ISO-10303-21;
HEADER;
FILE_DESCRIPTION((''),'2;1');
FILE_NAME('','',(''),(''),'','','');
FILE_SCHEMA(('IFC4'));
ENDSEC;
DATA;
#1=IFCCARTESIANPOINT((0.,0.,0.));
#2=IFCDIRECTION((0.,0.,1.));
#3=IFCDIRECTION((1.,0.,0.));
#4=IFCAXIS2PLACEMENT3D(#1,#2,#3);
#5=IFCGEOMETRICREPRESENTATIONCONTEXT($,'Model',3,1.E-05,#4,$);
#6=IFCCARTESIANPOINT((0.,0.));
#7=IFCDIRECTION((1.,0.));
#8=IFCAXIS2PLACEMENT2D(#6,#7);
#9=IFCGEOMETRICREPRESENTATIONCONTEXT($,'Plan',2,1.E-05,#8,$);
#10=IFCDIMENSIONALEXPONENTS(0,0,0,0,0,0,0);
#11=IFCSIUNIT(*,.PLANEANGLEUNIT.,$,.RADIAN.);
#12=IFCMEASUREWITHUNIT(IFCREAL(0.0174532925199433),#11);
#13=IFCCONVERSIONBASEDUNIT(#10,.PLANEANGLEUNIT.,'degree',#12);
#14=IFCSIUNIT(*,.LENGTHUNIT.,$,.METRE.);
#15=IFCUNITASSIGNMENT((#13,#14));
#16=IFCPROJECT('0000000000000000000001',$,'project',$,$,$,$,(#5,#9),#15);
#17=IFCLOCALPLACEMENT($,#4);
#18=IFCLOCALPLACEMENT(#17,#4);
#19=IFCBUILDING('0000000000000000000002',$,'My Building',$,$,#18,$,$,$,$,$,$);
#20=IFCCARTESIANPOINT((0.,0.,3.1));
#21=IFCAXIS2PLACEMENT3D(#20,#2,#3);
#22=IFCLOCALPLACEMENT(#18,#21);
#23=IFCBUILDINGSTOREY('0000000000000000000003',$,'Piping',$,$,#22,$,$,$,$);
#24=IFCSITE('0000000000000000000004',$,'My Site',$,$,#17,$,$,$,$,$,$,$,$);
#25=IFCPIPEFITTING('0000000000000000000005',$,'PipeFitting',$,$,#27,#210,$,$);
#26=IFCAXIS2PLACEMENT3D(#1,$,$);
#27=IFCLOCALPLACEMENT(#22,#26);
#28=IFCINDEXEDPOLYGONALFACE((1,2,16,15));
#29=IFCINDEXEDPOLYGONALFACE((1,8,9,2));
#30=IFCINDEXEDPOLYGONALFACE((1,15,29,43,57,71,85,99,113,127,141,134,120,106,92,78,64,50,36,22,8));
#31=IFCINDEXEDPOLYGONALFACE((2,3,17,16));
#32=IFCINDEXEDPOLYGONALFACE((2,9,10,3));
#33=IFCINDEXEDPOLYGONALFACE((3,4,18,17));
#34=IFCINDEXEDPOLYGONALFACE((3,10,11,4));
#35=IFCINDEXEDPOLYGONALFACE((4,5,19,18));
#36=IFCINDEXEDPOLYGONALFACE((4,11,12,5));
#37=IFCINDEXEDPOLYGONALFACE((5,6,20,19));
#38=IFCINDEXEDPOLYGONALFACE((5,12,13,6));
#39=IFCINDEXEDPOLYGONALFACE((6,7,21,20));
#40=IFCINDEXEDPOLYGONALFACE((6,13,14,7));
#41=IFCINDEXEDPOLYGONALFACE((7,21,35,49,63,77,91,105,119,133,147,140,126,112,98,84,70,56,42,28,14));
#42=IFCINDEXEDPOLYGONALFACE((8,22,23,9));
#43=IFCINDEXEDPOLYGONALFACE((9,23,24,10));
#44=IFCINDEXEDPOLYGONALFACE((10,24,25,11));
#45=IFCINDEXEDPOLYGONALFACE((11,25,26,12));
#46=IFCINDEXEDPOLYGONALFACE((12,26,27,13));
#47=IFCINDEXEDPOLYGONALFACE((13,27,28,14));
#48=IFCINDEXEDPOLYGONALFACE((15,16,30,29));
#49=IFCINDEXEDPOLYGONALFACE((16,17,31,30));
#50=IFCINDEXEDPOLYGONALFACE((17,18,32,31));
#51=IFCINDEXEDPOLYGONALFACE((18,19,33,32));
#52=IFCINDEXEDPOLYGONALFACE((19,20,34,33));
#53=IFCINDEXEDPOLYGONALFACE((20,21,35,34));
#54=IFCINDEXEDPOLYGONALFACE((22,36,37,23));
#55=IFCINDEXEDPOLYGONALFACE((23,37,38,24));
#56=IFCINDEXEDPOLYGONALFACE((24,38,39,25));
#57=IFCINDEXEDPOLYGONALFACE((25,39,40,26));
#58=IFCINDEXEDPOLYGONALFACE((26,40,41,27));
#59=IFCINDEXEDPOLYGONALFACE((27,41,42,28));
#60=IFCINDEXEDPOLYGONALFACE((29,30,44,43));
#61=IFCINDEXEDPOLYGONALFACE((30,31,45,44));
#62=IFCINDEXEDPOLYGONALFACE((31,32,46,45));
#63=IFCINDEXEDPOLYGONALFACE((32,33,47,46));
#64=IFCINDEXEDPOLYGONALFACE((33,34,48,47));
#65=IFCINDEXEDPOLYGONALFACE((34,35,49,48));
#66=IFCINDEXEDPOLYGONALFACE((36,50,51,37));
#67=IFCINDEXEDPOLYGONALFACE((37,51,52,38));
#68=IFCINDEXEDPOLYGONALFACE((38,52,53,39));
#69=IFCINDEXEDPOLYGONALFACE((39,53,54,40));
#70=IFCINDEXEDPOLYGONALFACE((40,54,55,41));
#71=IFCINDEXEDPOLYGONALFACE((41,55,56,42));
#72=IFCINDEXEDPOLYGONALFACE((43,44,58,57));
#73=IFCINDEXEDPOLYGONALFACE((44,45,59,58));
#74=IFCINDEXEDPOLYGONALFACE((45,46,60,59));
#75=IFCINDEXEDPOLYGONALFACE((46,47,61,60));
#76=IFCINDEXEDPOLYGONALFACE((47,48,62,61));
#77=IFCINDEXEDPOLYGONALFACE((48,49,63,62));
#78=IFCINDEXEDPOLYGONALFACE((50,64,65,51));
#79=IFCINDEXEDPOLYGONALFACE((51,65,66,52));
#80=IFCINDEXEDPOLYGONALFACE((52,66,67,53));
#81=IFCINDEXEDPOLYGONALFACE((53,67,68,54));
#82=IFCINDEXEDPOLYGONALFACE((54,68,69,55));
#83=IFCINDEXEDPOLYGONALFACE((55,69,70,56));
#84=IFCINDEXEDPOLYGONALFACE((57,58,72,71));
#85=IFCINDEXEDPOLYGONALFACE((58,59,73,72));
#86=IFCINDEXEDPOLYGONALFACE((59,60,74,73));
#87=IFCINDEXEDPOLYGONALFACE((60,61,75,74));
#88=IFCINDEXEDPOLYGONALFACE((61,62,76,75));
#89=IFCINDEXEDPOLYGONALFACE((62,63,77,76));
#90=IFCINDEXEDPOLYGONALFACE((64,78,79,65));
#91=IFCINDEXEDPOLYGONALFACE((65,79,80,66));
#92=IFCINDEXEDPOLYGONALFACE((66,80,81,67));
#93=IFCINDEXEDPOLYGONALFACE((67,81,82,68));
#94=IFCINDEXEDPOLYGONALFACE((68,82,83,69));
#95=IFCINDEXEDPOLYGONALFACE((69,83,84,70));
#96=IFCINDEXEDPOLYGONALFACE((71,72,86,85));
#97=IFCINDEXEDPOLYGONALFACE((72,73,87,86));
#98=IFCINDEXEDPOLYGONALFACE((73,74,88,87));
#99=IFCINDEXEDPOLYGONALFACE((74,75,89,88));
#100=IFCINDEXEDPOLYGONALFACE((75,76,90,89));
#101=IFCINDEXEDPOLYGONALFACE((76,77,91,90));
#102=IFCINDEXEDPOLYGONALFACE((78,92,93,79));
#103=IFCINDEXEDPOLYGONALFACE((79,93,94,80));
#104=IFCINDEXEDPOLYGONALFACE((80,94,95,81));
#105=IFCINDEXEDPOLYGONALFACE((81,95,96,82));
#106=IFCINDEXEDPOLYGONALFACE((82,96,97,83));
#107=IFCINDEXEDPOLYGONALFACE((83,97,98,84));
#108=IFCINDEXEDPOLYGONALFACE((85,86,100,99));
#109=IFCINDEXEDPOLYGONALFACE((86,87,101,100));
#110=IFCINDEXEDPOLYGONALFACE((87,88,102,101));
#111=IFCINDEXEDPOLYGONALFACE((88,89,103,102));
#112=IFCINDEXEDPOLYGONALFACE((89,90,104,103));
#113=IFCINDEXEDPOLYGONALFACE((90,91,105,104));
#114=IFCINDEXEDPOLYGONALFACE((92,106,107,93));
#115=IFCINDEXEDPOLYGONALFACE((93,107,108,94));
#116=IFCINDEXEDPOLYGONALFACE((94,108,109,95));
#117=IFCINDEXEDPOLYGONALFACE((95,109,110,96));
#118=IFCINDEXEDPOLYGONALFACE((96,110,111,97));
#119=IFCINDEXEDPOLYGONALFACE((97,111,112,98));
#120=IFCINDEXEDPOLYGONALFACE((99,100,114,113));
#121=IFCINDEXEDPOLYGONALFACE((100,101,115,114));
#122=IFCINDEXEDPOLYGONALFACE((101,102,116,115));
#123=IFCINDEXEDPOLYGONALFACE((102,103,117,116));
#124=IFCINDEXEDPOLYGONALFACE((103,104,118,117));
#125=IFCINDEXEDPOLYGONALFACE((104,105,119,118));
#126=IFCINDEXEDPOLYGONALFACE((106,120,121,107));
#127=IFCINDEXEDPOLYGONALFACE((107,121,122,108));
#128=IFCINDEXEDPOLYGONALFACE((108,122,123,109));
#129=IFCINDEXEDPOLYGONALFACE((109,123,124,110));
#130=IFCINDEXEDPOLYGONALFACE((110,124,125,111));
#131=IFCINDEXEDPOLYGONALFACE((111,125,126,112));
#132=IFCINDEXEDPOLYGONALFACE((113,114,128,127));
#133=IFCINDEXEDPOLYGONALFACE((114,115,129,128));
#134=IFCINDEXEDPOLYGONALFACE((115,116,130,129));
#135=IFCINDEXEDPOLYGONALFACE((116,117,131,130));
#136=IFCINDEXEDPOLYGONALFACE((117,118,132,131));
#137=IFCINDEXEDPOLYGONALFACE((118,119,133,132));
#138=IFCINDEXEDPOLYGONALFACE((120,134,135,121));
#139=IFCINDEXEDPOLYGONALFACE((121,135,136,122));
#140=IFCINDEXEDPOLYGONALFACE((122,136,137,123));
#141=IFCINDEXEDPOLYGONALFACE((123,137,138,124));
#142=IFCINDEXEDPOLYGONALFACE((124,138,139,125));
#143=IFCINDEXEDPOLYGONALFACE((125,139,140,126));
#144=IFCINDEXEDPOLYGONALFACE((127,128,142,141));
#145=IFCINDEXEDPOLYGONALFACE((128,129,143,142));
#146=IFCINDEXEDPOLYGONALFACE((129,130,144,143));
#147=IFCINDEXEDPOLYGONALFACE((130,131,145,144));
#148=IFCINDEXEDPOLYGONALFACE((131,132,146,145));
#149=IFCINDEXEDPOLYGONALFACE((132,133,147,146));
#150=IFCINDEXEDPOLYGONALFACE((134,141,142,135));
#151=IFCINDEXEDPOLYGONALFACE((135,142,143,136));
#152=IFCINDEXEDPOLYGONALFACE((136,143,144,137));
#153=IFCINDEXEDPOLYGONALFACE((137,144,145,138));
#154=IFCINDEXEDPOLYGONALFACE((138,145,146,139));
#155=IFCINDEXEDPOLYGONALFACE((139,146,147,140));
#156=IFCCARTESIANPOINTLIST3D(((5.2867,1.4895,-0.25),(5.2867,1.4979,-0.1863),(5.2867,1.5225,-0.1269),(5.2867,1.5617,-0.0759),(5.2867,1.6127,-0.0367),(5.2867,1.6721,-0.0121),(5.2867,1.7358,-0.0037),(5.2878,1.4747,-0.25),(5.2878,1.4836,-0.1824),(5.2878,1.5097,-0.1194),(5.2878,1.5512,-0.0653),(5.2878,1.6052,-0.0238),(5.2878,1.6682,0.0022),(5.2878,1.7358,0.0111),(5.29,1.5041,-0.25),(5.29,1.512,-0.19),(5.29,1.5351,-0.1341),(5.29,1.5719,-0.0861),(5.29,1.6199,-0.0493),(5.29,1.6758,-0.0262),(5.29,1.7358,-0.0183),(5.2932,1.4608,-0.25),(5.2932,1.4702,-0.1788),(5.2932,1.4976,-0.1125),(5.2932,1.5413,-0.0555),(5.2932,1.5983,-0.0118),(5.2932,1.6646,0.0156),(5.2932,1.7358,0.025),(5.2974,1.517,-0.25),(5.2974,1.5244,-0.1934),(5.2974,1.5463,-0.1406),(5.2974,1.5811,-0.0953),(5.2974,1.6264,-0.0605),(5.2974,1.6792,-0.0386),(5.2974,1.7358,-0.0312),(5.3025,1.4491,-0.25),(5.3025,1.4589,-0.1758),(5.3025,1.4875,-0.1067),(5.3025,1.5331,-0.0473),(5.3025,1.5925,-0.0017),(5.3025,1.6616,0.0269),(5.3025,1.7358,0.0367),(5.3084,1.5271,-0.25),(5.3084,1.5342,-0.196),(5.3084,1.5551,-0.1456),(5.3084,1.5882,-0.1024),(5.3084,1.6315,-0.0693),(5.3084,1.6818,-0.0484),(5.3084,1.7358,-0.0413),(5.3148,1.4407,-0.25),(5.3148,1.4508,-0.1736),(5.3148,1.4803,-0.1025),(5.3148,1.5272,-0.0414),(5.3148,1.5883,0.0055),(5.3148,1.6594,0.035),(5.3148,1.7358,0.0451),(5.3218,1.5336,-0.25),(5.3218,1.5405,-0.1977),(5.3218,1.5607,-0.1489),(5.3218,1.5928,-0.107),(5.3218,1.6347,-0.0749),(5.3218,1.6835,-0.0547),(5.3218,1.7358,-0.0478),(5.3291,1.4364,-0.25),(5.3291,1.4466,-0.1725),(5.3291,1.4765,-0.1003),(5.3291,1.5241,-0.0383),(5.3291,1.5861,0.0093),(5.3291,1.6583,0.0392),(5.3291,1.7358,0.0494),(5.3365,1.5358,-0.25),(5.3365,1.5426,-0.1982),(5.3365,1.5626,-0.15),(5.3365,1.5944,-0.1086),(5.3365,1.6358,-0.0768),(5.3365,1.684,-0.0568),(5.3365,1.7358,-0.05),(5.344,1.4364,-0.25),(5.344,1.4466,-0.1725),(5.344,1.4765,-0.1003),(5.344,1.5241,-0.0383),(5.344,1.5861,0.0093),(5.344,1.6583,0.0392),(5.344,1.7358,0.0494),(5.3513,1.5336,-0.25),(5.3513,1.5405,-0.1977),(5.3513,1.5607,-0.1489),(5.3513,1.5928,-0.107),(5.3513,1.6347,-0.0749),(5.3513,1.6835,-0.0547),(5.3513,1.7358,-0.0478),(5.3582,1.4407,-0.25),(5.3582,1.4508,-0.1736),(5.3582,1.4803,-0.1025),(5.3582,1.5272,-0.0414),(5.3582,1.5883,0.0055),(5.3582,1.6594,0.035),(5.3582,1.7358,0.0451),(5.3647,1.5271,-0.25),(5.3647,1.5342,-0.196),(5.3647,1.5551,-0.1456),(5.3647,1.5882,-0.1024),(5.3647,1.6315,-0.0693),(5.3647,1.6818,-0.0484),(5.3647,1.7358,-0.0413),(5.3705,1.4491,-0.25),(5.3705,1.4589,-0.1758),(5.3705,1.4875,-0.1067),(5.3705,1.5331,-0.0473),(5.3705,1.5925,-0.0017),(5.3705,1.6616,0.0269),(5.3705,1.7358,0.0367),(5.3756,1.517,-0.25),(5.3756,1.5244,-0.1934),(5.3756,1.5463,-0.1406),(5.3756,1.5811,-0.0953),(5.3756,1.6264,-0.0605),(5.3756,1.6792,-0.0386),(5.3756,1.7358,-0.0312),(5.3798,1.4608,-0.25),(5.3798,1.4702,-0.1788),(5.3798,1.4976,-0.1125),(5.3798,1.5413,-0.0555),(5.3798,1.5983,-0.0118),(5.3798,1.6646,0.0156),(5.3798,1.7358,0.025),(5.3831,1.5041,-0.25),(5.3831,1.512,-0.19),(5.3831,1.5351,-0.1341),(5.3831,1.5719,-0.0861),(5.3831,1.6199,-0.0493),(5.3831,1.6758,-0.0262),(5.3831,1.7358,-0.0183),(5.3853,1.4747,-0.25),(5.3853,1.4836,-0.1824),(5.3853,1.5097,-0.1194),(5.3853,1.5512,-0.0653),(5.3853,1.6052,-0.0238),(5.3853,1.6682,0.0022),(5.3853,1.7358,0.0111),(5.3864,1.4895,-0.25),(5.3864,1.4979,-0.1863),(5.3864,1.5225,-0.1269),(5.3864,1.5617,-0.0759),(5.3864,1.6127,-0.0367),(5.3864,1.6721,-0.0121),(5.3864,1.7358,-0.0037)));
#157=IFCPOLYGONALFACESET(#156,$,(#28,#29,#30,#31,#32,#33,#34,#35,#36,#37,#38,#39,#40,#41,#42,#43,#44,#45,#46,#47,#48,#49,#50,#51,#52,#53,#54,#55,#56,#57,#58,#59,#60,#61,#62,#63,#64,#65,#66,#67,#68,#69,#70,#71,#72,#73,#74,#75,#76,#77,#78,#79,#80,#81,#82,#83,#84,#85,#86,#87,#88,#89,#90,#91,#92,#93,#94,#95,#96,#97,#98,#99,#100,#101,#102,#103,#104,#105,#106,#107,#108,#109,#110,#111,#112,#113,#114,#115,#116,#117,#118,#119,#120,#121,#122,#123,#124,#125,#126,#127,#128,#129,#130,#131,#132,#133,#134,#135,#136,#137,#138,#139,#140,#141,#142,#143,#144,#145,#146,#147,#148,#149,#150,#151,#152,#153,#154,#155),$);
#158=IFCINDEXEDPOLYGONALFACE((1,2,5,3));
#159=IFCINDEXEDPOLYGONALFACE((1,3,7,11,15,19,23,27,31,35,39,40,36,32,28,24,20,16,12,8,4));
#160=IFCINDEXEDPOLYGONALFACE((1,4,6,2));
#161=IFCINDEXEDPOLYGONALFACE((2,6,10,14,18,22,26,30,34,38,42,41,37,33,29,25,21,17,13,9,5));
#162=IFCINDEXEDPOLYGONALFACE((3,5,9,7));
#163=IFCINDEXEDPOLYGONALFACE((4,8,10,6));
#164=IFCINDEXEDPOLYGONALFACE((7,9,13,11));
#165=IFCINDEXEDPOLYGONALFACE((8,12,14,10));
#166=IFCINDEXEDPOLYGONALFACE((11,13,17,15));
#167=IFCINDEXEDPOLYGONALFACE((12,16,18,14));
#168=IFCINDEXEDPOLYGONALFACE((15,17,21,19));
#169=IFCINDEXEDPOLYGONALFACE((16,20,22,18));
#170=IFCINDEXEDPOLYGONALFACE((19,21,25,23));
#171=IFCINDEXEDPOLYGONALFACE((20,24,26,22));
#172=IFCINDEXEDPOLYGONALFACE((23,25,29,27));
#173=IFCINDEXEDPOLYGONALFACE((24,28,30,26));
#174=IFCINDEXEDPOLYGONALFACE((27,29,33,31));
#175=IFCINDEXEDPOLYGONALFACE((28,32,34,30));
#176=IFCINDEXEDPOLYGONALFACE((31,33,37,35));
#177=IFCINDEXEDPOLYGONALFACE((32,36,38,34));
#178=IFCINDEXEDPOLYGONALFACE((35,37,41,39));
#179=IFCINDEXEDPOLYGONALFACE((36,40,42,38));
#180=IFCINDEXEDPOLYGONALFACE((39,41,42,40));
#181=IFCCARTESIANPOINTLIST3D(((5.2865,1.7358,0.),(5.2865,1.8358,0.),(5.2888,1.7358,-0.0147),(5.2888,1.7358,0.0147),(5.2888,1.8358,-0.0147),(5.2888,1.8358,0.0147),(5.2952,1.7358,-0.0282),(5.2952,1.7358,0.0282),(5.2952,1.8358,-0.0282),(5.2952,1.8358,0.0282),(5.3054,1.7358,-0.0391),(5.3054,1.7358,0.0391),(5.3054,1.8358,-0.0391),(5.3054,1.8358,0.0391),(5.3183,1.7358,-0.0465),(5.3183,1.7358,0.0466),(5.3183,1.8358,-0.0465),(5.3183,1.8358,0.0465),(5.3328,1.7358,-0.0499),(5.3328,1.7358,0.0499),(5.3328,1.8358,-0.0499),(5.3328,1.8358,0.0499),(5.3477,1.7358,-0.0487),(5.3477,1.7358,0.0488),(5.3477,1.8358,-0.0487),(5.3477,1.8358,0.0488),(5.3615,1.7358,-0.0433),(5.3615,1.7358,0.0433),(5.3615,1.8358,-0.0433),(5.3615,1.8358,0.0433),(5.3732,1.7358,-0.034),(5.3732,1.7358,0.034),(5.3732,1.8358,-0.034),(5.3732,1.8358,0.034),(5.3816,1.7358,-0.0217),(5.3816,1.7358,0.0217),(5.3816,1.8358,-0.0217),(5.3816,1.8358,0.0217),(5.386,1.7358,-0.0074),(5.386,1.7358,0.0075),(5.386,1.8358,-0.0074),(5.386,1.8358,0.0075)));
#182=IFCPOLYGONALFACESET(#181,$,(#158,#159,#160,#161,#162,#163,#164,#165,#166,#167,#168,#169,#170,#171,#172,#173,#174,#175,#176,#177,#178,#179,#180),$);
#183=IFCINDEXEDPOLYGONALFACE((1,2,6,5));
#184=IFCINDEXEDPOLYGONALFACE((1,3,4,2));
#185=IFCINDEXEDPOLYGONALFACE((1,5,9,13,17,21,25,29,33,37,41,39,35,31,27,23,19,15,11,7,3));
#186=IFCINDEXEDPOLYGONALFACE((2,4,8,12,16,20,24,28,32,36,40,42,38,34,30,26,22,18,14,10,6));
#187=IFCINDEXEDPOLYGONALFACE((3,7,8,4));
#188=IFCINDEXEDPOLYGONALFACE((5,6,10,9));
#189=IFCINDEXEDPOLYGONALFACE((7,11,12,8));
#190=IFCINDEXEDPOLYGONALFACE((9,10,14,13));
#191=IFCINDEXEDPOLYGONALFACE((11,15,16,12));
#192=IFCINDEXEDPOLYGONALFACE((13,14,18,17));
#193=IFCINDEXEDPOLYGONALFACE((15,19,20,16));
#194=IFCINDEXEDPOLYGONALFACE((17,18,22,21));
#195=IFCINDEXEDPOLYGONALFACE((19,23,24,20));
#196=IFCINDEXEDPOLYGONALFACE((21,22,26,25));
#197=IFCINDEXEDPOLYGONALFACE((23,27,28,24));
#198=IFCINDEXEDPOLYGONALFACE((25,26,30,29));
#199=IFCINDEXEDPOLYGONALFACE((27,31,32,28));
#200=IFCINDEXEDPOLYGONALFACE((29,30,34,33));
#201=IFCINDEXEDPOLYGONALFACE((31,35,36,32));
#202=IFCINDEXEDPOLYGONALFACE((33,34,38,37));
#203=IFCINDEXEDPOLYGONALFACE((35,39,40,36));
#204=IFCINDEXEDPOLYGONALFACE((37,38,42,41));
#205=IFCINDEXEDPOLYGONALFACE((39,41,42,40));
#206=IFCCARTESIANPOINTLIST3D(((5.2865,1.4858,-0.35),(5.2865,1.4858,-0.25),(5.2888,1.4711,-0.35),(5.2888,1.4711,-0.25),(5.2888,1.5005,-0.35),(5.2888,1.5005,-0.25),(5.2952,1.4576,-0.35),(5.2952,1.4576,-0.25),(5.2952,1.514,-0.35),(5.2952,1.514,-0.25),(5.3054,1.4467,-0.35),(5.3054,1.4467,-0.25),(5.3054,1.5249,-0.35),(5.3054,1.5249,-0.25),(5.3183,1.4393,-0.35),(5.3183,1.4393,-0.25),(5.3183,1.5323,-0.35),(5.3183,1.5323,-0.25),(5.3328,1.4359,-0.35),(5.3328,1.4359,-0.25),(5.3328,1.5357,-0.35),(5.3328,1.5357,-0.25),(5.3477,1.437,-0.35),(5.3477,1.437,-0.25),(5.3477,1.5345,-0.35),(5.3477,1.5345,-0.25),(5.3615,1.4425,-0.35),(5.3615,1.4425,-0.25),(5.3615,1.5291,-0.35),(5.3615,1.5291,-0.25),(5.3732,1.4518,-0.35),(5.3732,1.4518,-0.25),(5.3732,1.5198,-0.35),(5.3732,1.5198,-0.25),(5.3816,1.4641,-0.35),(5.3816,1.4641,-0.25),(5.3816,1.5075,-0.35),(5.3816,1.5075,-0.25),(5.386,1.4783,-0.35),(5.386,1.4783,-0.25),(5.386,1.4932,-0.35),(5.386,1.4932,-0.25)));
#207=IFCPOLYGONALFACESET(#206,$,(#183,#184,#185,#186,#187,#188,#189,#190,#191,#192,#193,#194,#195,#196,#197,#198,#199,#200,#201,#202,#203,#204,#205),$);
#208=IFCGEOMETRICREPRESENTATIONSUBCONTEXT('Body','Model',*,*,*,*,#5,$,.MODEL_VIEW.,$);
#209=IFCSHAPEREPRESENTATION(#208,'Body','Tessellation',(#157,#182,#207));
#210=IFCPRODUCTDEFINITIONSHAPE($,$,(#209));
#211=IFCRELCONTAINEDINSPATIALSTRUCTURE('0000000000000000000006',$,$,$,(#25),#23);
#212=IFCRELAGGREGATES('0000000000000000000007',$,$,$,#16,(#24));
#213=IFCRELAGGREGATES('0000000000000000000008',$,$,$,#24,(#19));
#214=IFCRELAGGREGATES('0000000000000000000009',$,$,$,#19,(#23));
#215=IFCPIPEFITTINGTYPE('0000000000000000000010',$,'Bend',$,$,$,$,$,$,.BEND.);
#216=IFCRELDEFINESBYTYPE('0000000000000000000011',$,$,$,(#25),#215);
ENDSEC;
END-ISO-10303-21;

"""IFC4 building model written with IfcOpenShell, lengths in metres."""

from ifc_helpers import new_model, entity, si_unit, converted_unit, frame, origin_with_axes, origin_2d_with_axis, place, context, subcontext, project, spatial, circle, extrude, source, transform, mapped, type_object, type_shapes, element, save


model = new_model("IFC4")

# Units and contexts
model_context = context("Model", 3, precision=1e-05, world=origin_with_axes())
plan_context = context("Plan", 2, precision=1e-05, world=origin_2d_with_axis())
body_context = subcontext(model_context, "Body", "Model", "MODEL_VIEW")
ifc_project = project(units=[converted_unit("PLANEANGLEUNIT", "degree", entity("IfcReal", 0.0174532925199433), si_unit("PLANEANGLEUNIT", "RADIAN"), dimensions=[0, 0, 0, 0, 0, 0, 0]), si_unit("LENGTHUNIT", "METRE")], contexts=[model_context, plan_context])

# Site, building, storey
site_placement = place(None, origin_with_axes())
site = spatial("IfcSite", under=ifc_project, at=site_placement, Name="My Site")
building_placement = place(site_placement, origin_with_axes())
building = spatial("IfcBuilding", under=site, at=building_placement, Name="My Building")
storey_placement = place(building_placement, frame((0.0, 0.0, 3.1), z_axis=(0.0, 0.0, 1.0), x_axis=(1.0, 0.0, 0.0)))
storey = spatial("IfcBuildingStorey", under=building, at=storey_placement, Name="Piping")

# Pipe fitting
pipe_fitting_type_1 = type_object("IfcPipeFittingType", Name="Bend", PredefinedType="BEND")
shared_shape_1 = source(origin_with_axes(), body_context, "Body", "SolidModel", [
    entity("IfcSweptDiskSolid", entity("IfcIndexedPolyCurve", entity("IfcCartesianPointList3D", [[0.0, 0.0, -0.1], [0.0, -0.0732, -0.2768], [0.0, -0.25, -0.35]]), [entity("IfcArcIndex", [1, 2, 3])]), 0.05),
    extrude(circle(Radius=0.05), origin_with_axes(), (0.0, 0.0, -1.0), 0.1),
    extrude(circle(Radius=0.05), frame((0.0, -0.25, -0.35), z_axis=(0.0, -1.0, 0.000022), x_axis=(1.0, 0.0, 0.0)), (0.0, 0.0, 1.0), 0.1),
])
type_shapes(pipe_fitting_type_1, [shared_shape_1])
for number, where, z_axis, x_axis, name in (
    (1, (5.3365, 1.8358, 0.0), (0.0, 1.0, -0.000022), (-1.0, 0.0, 0.0), "PipeFitting"),
):
    element("IfcPipeFitting", number, at=place(storey_placement, frame(where, z_axis=z_axis, x_axis=x_axis)), inside=storey, type_object=pipe_fitting_type_1, Name=name, context=body_context, shape_type="MappedRepresentation", body=[
        mapped(shared_shape_1, transform((0.0, 0.0, 0.0), x_axis=(1.0, 0.0, 0.0), y_axis=(0.0, 1.0, 0.0), z_axis=(0.0, 0.0, 1.0), scale=1.0)),
    ])

save(model, "model.ifc")
